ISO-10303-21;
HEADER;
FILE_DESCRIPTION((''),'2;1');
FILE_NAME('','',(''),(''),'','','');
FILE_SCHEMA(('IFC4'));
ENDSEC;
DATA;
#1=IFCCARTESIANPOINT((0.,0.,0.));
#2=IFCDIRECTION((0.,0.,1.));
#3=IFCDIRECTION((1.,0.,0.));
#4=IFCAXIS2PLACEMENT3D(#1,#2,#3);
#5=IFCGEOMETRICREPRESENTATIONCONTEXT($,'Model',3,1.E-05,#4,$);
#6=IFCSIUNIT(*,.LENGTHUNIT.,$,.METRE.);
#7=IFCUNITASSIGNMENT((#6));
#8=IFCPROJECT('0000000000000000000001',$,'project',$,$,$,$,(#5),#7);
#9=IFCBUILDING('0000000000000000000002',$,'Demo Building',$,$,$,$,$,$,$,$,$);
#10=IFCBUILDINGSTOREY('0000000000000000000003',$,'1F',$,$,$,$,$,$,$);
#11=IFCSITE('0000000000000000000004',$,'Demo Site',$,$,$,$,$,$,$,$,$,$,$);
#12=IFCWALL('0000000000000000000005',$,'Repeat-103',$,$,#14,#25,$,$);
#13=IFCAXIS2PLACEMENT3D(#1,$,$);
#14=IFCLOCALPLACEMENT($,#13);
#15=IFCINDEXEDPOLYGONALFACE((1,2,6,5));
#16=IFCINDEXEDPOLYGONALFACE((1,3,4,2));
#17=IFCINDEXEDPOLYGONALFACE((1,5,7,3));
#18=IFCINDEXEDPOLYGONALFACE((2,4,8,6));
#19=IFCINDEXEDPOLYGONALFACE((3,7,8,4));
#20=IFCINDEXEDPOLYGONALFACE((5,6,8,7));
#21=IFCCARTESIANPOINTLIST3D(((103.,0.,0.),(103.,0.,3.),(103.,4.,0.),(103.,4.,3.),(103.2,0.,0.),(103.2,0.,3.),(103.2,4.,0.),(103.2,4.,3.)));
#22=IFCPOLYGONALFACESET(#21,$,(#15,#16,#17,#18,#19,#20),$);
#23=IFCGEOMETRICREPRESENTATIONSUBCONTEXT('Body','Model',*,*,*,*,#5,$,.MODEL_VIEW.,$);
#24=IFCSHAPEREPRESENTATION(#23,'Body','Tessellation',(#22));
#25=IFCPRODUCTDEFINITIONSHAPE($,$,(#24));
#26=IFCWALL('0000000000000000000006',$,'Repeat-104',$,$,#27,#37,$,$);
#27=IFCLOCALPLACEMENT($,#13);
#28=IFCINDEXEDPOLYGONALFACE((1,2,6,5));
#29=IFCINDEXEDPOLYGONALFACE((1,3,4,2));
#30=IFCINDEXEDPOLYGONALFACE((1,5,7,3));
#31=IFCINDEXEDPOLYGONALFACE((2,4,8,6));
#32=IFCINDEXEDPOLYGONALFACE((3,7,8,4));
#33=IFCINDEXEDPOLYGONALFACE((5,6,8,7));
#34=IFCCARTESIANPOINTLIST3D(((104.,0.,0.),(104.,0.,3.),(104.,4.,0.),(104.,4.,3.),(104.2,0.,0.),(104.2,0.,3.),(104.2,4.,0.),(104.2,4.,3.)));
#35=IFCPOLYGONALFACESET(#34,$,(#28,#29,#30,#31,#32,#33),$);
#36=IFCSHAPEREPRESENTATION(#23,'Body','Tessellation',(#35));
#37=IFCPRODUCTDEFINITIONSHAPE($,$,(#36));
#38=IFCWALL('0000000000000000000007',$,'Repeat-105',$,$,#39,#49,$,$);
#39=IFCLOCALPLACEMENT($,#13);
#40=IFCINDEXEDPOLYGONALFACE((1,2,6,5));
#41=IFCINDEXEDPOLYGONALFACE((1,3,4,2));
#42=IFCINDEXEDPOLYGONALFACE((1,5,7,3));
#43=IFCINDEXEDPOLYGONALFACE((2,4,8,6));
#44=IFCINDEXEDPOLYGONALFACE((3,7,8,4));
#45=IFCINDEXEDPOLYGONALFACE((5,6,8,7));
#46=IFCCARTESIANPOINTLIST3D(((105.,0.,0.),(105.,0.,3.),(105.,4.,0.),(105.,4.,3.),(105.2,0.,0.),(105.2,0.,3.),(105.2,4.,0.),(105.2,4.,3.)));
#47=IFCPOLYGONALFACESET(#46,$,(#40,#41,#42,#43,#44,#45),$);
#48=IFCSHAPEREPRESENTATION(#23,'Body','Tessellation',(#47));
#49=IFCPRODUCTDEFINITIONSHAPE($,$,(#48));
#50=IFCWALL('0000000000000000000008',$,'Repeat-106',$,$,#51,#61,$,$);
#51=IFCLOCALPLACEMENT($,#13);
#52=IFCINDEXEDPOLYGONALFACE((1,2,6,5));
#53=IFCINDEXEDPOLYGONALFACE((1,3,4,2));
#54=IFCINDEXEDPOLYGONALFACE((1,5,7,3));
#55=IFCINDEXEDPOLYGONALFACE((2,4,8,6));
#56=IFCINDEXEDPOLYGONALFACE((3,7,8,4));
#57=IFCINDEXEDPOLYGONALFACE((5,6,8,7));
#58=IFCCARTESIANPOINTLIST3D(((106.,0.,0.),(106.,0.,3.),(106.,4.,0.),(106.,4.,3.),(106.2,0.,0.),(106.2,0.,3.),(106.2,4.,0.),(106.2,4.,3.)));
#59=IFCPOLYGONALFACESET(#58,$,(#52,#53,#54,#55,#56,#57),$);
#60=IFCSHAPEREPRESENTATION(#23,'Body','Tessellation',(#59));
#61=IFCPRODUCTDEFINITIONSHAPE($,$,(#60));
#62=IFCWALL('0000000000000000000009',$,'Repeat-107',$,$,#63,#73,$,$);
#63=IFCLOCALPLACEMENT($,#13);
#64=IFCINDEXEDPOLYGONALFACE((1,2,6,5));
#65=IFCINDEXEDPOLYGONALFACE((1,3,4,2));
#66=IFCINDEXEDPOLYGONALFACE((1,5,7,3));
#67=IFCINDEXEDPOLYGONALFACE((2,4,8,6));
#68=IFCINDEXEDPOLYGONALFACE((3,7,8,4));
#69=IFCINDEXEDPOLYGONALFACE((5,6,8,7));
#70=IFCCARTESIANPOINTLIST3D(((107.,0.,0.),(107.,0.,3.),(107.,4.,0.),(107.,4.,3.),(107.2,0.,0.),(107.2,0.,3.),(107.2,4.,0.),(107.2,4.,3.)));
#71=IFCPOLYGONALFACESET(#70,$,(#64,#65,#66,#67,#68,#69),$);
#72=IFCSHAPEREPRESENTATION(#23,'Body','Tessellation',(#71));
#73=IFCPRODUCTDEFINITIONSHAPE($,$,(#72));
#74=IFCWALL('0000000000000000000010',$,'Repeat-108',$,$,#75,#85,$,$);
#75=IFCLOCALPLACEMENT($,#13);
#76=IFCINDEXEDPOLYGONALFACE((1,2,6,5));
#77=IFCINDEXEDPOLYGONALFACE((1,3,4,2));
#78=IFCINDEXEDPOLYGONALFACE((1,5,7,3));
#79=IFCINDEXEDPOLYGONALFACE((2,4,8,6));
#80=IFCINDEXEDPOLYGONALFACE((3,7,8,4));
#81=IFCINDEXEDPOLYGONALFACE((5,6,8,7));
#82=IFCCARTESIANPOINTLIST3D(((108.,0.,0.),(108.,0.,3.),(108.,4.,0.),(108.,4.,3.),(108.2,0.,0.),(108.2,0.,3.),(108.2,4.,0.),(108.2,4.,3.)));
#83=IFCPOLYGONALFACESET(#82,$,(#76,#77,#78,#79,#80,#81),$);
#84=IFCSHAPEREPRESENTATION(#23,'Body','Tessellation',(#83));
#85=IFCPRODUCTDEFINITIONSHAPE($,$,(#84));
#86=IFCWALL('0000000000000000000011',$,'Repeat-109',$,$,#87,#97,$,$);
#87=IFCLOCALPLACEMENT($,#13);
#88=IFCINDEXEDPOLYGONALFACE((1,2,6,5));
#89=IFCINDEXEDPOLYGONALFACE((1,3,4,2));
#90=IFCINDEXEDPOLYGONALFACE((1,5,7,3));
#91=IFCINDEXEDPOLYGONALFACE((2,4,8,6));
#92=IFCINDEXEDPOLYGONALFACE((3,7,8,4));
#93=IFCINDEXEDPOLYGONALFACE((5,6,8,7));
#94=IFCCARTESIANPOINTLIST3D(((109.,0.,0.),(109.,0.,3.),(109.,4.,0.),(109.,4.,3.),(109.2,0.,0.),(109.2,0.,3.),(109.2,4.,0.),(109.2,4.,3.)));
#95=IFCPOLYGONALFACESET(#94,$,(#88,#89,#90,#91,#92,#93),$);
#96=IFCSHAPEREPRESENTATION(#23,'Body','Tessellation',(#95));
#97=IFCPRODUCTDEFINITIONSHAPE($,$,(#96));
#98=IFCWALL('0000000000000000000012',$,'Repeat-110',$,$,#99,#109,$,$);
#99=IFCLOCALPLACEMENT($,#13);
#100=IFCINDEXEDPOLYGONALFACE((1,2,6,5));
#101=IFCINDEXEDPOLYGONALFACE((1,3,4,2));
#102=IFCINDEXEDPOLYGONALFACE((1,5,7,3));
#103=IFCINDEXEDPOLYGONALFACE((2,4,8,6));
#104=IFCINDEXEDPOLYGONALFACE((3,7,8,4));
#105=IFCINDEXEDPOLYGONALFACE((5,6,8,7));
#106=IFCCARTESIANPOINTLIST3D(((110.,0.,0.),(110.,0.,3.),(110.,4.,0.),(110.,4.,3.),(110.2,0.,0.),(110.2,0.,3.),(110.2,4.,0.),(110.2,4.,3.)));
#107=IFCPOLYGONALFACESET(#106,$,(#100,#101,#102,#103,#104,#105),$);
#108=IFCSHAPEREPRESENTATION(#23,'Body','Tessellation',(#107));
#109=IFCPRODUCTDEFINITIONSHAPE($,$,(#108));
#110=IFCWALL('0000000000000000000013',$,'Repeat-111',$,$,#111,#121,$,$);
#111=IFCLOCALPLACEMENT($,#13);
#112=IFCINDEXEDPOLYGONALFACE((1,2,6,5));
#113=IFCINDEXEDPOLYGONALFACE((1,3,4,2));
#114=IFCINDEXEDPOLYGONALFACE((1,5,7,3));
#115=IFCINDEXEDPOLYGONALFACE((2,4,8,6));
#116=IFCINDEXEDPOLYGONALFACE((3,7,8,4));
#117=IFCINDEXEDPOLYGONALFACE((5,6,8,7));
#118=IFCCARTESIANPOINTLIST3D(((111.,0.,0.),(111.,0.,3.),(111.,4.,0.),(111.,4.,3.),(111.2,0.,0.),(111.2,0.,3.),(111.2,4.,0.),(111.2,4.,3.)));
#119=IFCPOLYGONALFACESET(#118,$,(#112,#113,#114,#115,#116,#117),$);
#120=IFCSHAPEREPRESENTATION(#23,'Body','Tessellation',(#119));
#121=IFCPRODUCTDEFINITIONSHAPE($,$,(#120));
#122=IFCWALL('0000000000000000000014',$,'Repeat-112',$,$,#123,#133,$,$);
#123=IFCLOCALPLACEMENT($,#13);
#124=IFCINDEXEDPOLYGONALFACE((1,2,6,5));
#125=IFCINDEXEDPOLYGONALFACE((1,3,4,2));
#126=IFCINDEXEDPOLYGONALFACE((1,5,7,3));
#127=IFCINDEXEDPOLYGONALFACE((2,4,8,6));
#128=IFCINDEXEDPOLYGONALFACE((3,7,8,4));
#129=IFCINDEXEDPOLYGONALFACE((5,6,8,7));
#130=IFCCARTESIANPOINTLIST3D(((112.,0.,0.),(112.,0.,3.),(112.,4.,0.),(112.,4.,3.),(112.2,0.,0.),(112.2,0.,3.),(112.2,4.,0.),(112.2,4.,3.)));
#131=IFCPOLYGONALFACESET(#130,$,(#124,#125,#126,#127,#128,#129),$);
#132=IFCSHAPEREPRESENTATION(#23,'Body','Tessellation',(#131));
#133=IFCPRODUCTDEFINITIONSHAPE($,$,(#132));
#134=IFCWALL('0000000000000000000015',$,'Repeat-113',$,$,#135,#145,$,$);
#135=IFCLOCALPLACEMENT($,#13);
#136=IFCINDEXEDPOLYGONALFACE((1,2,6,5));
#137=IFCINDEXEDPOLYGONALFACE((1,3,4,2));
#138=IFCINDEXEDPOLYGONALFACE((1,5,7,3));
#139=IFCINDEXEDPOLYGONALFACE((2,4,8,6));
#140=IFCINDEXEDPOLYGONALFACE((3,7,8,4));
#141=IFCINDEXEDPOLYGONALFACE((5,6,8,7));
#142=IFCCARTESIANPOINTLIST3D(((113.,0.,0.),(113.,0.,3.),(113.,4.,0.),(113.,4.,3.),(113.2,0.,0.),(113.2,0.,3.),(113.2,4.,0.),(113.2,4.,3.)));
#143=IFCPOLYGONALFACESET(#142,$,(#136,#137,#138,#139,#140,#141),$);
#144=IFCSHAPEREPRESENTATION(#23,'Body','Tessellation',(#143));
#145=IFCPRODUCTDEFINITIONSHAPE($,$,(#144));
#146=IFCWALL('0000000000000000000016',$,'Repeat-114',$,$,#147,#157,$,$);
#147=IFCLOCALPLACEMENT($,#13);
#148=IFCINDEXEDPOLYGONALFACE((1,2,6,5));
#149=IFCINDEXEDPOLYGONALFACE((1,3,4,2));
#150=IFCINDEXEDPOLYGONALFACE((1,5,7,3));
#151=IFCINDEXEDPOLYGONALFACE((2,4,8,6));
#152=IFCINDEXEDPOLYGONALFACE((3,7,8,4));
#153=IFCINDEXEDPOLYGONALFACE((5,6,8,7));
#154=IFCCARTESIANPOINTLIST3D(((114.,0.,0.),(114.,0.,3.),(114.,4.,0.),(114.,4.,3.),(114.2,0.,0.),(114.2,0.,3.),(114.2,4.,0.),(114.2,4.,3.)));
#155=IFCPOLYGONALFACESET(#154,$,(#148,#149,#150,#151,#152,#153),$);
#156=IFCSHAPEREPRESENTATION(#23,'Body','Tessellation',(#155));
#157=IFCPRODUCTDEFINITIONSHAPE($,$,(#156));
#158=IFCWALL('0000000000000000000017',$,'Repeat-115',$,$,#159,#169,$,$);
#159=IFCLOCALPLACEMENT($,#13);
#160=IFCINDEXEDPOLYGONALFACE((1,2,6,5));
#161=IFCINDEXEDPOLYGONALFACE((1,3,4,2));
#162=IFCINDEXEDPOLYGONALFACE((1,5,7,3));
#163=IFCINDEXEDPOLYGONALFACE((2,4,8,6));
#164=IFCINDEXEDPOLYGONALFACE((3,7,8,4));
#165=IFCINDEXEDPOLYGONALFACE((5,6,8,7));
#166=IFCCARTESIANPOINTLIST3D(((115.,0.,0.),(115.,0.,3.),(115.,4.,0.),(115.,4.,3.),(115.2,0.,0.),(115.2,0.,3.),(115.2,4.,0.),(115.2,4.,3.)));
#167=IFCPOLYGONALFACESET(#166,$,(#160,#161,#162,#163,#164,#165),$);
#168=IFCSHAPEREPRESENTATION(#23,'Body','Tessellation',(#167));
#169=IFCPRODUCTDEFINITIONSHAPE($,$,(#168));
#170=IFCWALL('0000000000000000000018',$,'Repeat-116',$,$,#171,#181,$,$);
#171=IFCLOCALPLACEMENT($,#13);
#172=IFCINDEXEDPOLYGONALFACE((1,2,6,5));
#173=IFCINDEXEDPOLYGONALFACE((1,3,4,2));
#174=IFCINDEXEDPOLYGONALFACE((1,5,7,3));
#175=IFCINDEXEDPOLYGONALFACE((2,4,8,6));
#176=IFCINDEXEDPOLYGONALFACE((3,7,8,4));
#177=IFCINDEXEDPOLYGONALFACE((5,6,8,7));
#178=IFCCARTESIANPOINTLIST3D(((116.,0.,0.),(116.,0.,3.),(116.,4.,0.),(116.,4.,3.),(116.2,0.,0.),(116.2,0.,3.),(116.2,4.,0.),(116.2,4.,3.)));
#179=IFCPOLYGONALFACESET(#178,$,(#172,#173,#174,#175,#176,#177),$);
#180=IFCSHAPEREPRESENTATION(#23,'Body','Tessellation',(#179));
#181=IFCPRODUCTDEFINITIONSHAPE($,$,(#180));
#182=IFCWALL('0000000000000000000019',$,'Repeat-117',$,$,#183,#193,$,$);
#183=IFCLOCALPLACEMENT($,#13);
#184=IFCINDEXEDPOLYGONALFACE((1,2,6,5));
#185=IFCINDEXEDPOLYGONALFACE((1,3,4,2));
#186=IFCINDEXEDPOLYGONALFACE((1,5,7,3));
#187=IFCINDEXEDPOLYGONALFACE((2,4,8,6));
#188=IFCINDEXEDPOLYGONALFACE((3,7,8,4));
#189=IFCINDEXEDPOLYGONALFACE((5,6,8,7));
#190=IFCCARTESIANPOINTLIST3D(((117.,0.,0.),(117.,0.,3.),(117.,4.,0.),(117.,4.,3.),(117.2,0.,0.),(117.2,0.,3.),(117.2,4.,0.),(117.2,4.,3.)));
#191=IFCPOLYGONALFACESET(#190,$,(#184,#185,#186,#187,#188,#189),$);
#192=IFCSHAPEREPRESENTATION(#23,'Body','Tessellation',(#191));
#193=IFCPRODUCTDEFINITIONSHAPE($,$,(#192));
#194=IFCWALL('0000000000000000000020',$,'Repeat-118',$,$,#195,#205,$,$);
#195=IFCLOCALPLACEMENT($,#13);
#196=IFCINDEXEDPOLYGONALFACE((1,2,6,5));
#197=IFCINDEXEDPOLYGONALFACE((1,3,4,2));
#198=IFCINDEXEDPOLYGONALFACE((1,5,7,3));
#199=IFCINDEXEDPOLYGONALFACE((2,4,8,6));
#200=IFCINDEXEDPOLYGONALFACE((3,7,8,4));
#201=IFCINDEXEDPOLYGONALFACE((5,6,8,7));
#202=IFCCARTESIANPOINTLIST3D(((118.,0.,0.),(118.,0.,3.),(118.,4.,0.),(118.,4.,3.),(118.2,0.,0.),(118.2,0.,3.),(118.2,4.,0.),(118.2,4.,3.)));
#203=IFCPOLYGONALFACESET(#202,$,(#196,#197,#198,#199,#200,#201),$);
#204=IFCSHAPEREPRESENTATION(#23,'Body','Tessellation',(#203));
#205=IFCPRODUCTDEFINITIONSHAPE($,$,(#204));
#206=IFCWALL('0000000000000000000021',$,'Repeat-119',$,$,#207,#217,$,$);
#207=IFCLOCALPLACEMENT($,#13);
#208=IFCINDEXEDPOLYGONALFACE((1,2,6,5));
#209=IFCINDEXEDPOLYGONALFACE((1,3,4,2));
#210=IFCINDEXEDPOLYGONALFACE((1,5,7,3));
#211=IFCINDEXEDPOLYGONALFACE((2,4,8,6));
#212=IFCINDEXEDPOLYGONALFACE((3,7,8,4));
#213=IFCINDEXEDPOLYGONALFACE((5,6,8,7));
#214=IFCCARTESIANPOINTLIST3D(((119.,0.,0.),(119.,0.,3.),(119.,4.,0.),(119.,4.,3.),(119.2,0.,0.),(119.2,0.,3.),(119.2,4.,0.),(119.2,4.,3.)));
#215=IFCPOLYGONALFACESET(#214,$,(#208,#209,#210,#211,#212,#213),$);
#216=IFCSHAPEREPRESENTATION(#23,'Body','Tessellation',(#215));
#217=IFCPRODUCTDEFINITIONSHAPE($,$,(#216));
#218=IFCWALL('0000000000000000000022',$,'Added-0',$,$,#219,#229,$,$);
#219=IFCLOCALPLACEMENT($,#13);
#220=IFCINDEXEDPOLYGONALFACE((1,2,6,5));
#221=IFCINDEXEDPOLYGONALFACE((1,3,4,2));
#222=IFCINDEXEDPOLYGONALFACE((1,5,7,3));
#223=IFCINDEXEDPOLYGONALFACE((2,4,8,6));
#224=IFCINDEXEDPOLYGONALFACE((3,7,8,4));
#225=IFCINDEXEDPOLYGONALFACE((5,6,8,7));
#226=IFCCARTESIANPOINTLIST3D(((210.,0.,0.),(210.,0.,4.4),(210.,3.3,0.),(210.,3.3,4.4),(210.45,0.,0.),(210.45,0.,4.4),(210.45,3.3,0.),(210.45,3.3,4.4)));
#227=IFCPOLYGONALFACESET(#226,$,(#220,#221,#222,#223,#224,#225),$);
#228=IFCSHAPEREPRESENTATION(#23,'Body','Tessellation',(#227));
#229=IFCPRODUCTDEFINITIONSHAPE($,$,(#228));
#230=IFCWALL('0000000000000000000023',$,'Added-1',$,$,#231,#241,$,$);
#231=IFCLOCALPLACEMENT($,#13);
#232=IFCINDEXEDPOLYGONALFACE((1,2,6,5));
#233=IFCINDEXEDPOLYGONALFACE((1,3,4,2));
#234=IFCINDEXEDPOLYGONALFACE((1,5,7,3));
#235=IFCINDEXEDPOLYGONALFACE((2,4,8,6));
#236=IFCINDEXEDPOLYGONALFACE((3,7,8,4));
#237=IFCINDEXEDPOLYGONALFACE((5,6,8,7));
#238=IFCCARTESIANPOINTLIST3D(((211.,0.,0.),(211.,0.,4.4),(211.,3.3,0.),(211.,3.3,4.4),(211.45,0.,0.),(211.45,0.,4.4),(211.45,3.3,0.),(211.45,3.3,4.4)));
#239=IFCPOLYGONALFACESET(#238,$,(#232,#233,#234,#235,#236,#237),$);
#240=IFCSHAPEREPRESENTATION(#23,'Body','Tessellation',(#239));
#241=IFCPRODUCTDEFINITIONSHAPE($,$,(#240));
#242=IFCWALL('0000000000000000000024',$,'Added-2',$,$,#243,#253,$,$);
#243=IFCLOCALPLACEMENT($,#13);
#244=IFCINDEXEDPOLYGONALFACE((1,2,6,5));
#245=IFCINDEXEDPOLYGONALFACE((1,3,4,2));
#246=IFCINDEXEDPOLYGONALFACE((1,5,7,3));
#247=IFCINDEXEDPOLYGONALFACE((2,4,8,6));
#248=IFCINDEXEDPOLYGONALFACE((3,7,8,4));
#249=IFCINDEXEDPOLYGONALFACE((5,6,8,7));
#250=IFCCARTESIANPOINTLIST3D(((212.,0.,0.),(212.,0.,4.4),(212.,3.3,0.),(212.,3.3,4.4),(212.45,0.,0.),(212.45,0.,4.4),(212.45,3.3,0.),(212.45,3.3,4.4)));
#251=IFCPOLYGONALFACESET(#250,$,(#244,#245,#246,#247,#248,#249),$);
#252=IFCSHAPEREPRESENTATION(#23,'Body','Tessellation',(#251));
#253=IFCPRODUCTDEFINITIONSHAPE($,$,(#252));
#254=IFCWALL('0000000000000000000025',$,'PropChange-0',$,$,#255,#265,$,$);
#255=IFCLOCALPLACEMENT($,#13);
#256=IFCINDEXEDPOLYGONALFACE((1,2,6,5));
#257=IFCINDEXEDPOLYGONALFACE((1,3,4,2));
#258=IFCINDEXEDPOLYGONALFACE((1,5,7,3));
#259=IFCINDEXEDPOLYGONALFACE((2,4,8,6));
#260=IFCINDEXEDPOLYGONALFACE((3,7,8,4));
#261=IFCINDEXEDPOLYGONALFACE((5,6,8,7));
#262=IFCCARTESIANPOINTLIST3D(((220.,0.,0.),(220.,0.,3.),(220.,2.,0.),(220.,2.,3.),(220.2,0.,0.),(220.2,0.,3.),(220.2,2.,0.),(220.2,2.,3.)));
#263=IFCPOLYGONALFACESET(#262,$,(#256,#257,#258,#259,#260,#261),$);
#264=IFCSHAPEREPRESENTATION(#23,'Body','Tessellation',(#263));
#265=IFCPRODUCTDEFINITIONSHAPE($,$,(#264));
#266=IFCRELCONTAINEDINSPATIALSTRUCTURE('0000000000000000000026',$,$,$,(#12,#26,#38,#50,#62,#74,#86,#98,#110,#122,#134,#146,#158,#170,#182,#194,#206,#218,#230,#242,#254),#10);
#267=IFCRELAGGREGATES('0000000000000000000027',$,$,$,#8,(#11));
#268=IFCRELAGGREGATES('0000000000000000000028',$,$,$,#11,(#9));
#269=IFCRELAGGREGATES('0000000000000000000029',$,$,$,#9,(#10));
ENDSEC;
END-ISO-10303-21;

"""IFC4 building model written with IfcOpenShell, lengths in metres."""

from ifc_helpers import new_model, entity, si_unit, frame, origin_with_axes, place, context, subcontext, project, spatial, element, save


model = new_model("IFC4")

# Units and contexts
model_context = context("Model", 3, precision=1e-05, world=origin_with_axes())
body_context = subcontext(model_context, "Body", "Model", "MODEL_VIEW")
ifc_project = project(units=[si_unit("LENGTHUNIT", "METRE")], contexts=[model_context])

# Site, building, storey
site = spatial("IfcSite", under=ifc_project, Name="Demo Site")
building = spatial("IfcBuilding", under=site, Name="Demo Building")
storey = spatial("IfcBuildingStorey", under=building, Name="1F")

# Walls
for number, where, z_axis, x_axis, name in (
    (1, (103.0, 0.0, 0.0), (0.0, 0.0, 1.0), (1.0, 0.0, 0.0), "Repeat-103"),
    (2, (104.0, 0.0, 0.0), (0.0, 0.0, 1.0), (1.0, 0.0, 0.0), "Repeat-104"),
    (3, (105.0, 0.0, 0.0), (0.0, 0.0, 1.0), (1.0, 0.0, 0.0), "Repeat-105"),
    (4, (106.0, 0.0, 0.0), (0.0, 0.0, 1.0), (1.0, 0.0, 0.0), "Repeat-106"),
    (5, (107.0, 0.0, 0.0), (0.0, 0.0, 1.0), (1.0, 0.0, 0.0), "Repeat-107"),
    (6, (108.0, 0.0, 0.0), (0.0, 0.0, 1.0), (1.0, 0.0, 0.0), "Repeat-108"),
    (7, (109.0, 0.0, 0.0), (0.0, 0.0, 1.0), (1.0, 0.0, 0.0), "Repeat-109"),
    (8, (110.0, 0.0, 0.0), (0.0, 0.0, 1.0), (1.0, 0.0, 0.0), "Repeat-110"),
    (9, (111.0, 0.0, 0.0), (0.0, 0.0, 1.0), (1.0, 0.0, 0.0), "Repeat-111"),
    (10, (112.0, 0.0, 0.0), (0.0, 0.0, 1.0), (1.0, 0.0, 0.0), "Repeat-112"),
    (11, (113.0, 0.0, 0.0), (0.0, 0.0, 1.0), (1.0, 0.0, 0.0), "Repeat-113"),
    (12, (114.0, 0.0, 0.0), (0.0, 0.0, 1.0), (1.0, 0.0, 0.0), "Repeat-114"),
    (13, (115.0, 0.0, 0.0), (0.0, 0.0, 1.0), (1.0, 0.0, 0.0), "Repeat-115"),
    (14, (116.0, 0.0, 0.0), (0.0, 0.0, 1.0), (1.0, 0.0, 0.0), "Repeat-116"),
    (15, (117.0, 0.0, 0.0), (0.0, 0.0, 1.0), (1.0, 0.0, 0.0), "Repeat-117"),
    (16, (118.0, 0.0, 0.0), (0.0, 0.0, 1.0), (1.0, 0.0, 0.0), "Repeat-118"),
    (17, (119.0, 0.0, 0.0), (0.0, 0.0, 1.0), (1.0, 0.0, 0.0), "Repeat-119"),
):
    element("IfcWall", number, at=place(None, frame(where, z_axis=z_axis, x_axis=x_axis)), inside=storey, Name=name, context=body_context, shape_type="CSG", body=[
        entity("IfcBlock", entity("IfcAxis2Placement3D", entity("IfcCartesianPoint", [0.0, 0.0, 0.0]), entity("IfcDirection", [0.0, 0.0, 1.0]), entity("IfcDirection", [1.0, 0.0, 0.0])), 0.2, 4.0, 3.0),
    ])
for number, where, z_axis, x_axis, name in (
    (18, (210.0, 0.0, 0.0), (0.0, 0.0, 1.0), (1.0, 0.0, 0.0), "Added-0"),
    (19, (211.0, 0.0, 0.0), (0.0, 0.0, 1.0), (1.0, 0.0, 0.0), "Added-1"),
    (20, (212.0, 0.0, 0.0), (0.0, 0.0, 1.0), (1.0, 0.0, 0.0), "Added-2"),
):
    element("IfcWall", number, at=place(None, frame(where, z_axis=z_axis, x_axis=x_axis)), inside=storey, Name=name, context=body_context, shape_type="CSG", body=[
        entity("IfcBlock", entity("IfcAxis2Placement3D", entity("IfcCartesianPoint", [0.0, 0.0, 0.0]), entity("IfcDirection", [0.0, 0.0, 1.0]), entity("IfcDirection", [1.0, 0.0, 0.0])), 0.45, 3.3, 4.4),
    ])
for number, where, z_axis, x_axis, name in (
    (21, (220.0, 0.0, 0.0), (0.0, 0.0, 1.0), (1.0, 0.0, 0.0), "PropChange-0"),
):
    element("IfcWall", number, at=place(None, frame(where, z_axis=z_axis, x_axis=x_axis)), inside=storey, Name=name, context=body_context, shape_type="CSG", body=[
        entity("IfcBlock", entity("IfcAxis2Placement3D", entity("IfcCartesianPoint", [0.0, 0.0, 0.0]), entity("IfcDirection", [0.0, 0.0, 1.0]), entity("IfcDirection", [1.0, 0.0, 0.0])), 0.2, 2.0, 3.0),
    ])

save(model, "model.ifc")
